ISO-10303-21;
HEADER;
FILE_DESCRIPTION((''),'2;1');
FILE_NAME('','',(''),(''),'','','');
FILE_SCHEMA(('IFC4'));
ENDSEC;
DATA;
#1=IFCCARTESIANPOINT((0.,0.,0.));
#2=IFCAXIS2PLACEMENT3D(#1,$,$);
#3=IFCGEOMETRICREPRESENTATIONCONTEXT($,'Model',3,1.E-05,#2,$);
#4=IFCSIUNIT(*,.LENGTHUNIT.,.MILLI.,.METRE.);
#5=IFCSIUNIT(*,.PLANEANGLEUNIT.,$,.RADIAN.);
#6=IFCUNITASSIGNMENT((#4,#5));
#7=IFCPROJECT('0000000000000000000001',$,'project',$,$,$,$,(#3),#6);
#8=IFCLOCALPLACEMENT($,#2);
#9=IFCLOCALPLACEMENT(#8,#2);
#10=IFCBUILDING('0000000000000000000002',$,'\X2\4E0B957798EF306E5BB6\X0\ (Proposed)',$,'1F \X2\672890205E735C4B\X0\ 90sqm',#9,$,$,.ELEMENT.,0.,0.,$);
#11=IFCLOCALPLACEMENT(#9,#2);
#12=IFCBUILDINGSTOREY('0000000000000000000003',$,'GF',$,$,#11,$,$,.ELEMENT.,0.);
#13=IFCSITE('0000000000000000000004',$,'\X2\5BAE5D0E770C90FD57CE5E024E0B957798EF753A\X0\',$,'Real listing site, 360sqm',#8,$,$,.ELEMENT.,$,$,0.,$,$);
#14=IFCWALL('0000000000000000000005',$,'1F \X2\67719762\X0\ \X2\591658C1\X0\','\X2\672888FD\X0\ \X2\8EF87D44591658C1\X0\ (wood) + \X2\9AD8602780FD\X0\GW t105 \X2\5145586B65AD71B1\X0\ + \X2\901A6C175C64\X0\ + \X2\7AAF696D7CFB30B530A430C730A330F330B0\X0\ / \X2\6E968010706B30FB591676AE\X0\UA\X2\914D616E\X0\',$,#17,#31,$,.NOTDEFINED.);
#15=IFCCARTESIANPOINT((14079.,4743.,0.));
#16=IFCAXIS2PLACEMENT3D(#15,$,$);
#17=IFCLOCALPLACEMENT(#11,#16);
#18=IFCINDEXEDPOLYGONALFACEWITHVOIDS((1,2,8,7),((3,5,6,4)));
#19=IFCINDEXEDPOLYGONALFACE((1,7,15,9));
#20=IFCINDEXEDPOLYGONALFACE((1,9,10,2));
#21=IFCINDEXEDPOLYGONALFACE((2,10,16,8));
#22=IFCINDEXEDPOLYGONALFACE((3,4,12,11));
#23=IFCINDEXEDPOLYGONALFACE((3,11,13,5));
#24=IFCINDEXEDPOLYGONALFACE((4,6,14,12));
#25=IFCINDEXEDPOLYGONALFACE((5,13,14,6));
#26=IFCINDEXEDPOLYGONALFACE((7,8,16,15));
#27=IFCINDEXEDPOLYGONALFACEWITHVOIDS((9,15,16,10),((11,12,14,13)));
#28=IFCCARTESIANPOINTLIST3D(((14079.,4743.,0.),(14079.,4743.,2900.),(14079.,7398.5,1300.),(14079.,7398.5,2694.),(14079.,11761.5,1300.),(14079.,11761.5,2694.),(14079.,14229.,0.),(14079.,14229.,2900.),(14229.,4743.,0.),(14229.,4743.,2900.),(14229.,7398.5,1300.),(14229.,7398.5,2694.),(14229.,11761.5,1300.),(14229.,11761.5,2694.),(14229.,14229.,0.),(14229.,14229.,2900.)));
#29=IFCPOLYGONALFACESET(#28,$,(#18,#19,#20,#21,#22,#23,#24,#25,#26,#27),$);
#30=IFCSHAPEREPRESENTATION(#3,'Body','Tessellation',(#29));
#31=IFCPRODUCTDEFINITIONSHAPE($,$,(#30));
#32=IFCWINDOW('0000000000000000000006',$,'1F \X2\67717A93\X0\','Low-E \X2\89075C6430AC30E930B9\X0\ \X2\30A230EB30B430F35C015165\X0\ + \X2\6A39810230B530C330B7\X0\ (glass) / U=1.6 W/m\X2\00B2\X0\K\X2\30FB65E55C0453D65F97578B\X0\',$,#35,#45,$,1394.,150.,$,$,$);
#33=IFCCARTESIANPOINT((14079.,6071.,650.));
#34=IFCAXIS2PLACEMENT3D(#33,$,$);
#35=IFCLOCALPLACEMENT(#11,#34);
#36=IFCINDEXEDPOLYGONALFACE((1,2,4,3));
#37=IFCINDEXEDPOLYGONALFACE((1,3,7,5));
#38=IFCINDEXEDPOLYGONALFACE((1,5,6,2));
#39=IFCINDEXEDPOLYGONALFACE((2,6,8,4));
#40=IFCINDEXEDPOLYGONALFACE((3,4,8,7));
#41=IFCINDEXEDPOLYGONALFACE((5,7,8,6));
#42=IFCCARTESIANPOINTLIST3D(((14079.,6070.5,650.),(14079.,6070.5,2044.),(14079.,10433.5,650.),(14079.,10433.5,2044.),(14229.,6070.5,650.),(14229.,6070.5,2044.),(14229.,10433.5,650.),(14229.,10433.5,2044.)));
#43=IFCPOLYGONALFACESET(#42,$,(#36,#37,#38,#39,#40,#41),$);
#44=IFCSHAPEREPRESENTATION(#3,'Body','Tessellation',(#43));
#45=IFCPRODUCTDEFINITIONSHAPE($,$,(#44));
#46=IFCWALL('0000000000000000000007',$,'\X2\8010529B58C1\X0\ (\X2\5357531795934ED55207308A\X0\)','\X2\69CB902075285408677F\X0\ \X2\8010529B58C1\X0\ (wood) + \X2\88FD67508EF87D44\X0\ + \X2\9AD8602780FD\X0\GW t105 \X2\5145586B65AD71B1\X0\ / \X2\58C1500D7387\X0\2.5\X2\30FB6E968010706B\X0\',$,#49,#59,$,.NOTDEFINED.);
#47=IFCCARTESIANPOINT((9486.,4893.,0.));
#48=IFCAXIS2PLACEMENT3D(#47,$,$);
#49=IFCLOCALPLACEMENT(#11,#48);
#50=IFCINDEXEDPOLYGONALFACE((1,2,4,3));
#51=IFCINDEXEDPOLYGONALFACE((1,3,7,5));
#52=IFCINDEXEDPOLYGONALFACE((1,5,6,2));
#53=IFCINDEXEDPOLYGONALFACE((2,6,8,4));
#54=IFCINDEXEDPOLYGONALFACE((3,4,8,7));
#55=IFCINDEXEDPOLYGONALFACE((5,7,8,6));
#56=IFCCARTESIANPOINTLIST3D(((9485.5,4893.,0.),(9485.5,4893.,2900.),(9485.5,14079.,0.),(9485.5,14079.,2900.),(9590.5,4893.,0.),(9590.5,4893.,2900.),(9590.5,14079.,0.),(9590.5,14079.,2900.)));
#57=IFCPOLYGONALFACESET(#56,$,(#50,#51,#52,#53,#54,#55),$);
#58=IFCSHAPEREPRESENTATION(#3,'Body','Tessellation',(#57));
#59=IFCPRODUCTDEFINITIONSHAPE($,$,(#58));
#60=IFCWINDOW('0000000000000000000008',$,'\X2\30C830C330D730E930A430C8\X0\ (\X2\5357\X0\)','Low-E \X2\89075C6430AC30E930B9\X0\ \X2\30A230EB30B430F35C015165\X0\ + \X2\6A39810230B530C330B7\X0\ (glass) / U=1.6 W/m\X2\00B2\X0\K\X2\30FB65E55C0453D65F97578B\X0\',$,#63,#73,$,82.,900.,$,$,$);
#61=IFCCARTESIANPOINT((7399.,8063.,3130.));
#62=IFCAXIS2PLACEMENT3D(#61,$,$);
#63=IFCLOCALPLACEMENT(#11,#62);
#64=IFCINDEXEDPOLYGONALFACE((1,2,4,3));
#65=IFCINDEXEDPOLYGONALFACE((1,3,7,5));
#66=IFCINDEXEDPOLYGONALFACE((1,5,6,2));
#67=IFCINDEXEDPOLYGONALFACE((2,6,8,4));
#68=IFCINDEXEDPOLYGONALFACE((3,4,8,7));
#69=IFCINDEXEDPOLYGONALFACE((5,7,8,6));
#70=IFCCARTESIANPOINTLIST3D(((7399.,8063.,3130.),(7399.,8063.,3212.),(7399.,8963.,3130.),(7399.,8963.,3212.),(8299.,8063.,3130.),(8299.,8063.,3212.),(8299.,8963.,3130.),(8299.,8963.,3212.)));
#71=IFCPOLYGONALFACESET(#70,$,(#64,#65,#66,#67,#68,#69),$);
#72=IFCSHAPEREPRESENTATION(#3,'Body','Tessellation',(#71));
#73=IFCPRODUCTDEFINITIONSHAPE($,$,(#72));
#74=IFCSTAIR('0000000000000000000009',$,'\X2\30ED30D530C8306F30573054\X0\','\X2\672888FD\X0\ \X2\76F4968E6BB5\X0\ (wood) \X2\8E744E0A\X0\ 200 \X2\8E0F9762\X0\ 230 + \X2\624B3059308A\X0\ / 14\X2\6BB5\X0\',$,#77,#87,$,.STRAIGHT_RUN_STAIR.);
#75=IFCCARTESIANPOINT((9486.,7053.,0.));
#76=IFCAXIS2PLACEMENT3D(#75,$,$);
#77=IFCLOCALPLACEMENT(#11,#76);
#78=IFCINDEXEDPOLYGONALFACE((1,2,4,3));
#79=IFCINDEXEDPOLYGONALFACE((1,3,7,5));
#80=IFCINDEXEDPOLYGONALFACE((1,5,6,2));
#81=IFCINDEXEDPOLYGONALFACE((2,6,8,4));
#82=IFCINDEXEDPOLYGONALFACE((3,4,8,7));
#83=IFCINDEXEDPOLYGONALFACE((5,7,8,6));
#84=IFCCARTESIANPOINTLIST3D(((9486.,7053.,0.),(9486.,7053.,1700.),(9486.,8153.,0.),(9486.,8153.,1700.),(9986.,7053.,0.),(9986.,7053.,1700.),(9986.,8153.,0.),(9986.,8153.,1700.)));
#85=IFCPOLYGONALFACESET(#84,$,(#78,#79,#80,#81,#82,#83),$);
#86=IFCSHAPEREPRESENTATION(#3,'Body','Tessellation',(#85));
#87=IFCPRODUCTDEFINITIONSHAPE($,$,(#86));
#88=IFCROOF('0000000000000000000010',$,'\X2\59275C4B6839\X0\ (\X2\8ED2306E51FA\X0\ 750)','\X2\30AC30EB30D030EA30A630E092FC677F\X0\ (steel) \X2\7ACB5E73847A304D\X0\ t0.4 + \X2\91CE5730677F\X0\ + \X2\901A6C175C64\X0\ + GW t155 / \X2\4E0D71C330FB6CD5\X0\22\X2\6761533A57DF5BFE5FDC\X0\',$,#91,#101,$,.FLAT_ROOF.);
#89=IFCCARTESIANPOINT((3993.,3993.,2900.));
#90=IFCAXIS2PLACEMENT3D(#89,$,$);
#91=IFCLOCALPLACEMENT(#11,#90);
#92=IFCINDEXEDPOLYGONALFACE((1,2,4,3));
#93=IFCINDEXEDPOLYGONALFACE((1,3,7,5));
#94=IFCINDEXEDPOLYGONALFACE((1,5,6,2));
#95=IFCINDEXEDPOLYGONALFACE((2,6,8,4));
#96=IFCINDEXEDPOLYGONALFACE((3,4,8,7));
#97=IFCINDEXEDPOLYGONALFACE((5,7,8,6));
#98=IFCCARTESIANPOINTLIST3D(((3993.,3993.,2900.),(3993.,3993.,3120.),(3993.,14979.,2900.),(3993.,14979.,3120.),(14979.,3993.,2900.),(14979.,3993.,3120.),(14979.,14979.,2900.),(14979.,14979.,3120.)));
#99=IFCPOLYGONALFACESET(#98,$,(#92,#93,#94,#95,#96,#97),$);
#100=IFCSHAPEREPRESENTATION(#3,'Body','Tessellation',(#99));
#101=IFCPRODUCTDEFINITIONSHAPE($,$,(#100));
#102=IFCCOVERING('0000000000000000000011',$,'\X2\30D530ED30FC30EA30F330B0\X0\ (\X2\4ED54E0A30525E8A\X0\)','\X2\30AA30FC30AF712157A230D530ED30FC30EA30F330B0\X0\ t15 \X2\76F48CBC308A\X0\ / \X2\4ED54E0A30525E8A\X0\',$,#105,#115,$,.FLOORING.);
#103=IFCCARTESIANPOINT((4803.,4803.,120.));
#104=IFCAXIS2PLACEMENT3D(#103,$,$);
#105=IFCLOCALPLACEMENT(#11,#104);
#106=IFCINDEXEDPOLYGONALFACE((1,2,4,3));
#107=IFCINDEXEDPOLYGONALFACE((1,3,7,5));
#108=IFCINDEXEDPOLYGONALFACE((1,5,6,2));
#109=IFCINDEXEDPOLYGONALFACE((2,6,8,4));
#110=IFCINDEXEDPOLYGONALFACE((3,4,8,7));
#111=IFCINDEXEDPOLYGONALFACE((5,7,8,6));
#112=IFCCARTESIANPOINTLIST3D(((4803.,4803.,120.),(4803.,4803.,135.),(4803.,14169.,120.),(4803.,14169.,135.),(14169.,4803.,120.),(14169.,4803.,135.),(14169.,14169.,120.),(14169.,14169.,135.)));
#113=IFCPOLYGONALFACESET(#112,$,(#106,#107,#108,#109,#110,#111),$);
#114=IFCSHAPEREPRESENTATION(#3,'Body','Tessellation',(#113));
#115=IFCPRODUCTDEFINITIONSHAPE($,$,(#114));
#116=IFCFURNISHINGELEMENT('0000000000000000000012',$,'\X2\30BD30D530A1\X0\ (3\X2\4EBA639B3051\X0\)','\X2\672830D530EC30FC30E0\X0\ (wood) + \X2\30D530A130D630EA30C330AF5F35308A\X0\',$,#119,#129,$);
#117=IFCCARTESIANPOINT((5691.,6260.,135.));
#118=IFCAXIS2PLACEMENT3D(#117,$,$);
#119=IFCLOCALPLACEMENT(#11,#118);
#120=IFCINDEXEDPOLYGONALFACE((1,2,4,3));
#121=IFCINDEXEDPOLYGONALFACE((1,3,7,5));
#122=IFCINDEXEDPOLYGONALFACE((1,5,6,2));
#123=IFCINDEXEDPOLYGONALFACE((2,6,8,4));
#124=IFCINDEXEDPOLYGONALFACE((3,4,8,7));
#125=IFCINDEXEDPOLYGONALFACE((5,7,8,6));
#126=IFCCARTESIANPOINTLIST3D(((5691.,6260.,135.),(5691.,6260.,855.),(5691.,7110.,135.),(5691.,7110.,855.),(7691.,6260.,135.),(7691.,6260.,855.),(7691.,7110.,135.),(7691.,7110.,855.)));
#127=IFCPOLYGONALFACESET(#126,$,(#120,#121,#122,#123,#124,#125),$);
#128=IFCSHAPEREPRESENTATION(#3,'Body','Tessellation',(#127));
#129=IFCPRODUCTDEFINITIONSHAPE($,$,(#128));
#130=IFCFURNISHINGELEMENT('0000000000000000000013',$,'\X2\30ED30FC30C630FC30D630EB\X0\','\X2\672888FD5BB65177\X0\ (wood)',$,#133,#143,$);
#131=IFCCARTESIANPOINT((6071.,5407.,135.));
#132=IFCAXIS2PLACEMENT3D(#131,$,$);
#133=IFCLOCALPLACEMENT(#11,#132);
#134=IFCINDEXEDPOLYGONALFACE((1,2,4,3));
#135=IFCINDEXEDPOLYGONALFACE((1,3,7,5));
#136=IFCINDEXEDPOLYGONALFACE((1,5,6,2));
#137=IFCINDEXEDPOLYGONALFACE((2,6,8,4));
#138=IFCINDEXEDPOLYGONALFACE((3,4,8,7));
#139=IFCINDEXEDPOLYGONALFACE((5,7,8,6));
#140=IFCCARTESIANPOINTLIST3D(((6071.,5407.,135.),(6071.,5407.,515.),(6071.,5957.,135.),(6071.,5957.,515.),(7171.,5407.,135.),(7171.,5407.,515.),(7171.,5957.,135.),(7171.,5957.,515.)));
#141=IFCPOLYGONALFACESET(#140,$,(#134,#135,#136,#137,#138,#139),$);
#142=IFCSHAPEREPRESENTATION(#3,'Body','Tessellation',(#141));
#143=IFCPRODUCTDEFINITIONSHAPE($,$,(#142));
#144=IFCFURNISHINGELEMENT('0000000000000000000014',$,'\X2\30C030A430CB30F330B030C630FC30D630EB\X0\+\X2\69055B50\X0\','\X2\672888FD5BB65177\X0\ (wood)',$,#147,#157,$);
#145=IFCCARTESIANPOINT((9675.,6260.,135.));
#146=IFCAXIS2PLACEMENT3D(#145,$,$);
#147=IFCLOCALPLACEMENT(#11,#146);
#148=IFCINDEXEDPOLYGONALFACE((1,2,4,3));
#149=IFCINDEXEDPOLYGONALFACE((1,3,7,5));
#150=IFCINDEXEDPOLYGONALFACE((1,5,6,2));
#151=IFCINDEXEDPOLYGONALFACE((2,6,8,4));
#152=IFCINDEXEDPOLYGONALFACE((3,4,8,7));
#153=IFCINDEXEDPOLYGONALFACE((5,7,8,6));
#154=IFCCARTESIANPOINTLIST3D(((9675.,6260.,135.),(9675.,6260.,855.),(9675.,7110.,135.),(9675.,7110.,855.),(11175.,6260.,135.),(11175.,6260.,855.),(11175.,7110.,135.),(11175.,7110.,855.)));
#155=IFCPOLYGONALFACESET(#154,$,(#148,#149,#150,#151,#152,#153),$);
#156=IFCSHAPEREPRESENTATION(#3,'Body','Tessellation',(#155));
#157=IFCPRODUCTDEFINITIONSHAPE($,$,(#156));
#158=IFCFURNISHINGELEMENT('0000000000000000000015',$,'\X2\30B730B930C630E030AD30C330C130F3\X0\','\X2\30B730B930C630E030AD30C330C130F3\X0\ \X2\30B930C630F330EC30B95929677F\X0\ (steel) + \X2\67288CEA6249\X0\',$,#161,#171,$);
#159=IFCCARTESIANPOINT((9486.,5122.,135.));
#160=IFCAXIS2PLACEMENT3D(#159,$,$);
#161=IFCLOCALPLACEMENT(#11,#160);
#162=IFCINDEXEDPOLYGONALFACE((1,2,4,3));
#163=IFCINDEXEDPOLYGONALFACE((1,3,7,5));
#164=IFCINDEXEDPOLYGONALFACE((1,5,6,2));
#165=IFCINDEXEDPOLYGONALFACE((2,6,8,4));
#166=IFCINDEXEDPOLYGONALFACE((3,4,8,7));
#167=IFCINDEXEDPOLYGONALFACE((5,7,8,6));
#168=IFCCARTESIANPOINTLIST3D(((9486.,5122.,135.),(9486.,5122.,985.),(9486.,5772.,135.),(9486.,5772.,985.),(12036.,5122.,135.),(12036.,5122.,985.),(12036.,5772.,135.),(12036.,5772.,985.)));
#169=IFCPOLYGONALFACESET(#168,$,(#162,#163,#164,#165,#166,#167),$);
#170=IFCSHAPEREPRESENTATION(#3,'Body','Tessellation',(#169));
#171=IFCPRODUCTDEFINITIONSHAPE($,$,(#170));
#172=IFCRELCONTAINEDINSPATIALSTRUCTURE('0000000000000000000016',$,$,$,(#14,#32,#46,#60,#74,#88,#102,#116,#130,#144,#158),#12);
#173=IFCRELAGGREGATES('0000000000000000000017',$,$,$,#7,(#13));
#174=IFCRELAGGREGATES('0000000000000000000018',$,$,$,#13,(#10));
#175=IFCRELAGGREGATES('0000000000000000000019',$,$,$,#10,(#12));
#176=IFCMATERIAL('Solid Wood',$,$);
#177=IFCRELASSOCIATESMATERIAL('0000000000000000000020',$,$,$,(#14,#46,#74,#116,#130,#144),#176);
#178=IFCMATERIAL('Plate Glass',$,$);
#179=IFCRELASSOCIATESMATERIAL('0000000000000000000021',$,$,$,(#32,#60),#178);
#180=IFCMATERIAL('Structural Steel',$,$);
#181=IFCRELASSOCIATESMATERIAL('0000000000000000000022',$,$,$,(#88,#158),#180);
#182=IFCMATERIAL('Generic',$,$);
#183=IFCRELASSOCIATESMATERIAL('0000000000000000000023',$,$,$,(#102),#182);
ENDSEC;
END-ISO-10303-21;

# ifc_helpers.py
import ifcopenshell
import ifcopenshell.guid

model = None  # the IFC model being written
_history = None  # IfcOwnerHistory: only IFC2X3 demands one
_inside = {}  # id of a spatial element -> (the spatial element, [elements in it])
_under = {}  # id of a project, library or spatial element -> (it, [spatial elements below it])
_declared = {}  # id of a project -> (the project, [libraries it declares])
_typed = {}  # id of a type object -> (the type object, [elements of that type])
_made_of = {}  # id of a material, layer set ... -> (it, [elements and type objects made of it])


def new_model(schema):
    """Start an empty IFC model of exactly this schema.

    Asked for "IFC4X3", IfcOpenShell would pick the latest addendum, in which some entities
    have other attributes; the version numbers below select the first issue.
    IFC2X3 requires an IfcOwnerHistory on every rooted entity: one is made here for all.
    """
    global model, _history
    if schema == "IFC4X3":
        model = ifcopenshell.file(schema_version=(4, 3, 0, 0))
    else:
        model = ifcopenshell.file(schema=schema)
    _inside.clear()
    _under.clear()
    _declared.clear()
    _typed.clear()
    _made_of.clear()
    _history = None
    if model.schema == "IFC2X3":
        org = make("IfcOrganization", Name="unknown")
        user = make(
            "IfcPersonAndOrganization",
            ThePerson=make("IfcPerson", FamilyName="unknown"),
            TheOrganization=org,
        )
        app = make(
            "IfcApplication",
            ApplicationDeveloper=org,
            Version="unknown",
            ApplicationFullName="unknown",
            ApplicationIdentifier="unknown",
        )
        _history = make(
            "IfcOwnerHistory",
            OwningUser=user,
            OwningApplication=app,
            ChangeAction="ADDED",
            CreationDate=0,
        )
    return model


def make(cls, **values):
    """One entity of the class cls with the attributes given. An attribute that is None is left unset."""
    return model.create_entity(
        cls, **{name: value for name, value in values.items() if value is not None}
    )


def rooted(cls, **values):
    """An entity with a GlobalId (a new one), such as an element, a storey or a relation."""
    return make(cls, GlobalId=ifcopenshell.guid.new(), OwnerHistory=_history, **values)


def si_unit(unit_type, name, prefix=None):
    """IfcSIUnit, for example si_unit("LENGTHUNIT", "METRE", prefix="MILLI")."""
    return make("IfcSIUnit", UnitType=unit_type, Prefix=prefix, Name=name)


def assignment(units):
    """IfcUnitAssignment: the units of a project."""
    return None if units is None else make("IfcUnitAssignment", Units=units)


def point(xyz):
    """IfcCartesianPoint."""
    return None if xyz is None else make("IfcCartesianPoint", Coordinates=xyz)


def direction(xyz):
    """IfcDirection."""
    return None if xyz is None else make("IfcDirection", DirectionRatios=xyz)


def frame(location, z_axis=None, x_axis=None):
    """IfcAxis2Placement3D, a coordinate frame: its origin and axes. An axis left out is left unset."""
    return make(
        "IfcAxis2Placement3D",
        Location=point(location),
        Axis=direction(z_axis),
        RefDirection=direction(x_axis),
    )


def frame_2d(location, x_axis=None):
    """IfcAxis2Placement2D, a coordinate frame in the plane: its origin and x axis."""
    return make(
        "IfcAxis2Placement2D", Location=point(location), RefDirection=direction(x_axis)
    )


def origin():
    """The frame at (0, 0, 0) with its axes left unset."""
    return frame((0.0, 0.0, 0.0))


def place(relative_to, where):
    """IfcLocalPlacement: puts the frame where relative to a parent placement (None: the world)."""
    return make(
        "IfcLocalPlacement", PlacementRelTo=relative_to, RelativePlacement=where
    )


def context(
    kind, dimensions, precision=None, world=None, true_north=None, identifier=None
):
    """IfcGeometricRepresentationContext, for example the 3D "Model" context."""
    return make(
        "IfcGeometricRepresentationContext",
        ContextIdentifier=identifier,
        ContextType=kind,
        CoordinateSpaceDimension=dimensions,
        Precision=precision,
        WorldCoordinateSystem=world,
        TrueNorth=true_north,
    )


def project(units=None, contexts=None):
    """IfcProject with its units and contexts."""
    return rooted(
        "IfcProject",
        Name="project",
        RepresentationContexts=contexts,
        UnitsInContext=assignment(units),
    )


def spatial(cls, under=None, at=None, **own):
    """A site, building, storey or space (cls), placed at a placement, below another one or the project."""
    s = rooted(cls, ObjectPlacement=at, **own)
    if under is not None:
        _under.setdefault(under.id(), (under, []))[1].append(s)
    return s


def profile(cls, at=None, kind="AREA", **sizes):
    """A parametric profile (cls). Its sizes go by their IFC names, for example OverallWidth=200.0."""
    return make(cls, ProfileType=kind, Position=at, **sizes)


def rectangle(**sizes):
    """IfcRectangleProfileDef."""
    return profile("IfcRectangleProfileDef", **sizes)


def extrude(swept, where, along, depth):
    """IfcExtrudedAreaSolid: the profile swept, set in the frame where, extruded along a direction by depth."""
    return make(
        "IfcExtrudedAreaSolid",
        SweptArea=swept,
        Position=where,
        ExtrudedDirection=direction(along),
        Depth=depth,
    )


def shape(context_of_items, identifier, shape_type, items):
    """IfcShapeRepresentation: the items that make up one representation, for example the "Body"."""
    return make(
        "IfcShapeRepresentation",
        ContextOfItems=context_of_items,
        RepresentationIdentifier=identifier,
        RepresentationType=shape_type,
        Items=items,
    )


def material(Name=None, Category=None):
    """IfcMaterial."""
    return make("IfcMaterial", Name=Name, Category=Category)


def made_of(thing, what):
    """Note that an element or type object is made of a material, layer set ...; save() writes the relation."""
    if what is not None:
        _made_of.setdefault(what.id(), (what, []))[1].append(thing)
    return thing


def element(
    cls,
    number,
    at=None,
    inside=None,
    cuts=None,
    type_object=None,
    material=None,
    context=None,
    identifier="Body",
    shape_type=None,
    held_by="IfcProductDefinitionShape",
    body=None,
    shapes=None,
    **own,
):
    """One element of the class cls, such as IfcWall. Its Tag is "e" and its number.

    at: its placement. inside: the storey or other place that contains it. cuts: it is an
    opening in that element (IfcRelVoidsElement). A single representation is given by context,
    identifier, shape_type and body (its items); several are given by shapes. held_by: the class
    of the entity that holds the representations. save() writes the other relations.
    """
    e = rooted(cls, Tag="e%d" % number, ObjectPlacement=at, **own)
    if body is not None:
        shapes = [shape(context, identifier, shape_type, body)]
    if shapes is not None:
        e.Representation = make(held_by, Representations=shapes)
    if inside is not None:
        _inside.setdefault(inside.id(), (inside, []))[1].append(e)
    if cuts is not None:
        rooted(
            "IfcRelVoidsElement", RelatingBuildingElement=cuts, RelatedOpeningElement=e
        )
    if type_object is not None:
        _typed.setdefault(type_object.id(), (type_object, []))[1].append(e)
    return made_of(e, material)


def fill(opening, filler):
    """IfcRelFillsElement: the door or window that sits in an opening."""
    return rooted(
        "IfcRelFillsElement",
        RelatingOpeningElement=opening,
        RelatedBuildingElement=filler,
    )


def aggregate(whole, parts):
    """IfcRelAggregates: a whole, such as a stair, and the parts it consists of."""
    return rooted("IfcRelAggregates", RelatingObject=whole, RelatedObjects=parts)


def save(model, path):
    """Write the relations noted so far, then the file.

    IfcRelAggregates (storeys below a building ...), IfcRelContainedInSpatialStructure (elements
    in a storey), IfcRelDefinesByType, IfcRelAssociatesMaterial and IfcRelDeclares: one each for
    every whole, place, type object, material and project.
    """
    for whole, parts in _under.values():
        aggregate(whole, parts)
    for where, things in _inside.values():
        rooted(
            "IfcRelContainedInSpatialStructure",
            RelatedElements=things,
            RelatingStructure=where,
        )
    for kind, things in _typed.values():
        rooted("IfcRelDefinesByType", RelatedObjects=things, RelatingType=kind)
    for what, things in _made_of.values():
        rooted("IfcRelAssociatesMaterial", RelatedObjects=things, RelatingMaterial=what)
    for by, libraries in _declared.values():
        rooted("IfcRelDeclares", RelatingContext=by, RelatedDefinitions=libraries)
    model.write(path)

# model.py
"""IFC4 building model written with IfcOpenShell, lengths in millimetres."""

from ifc_helpers import new_model, si_unit, frame, frame_2d, origin, place, context, project, spatial, rectangle, extrude, material, element, fill, save


model = new_model("IFC4")

# Units and contexts
model_context = context("Model", 3, precision=1e-05, world=origin())
ifc_project = project(units=[si_unit("LENGTHUNIT", "METRE", prefix="MILLI"), si_unit("PLANEANGLEUNIT", "RADIAN")], contexts=[model_context])

# Site, building, storey
site_placement = place(None, origin())
site = spatial("IfcSite", under=ifc_project, at=site_placement, Name="宮崎県都城市下長飯町", ObjectType="Real listing site, 360sqm", CompositionType="ELEMENT", RefElevation=0.0)
building_placement = place(site_placement, origin())
building = spatial("IfcBuilding", under=site, at=building_placement, Name="下長飯の家 (Proposed)", ObjectType="1F 木造平屋 90sqm", CompositionType="ELEMENT", ElevationOfRefHeight=0.0, ElevationOfTerrain=0.0)
storey_placement = place(building_placement, origin())
storey = spatial("IfcBuildingStorey", under=building, at=storey_placement, Name="GF", CompositionType="ELEMENT", Elevation=0.0)

# Shared definitions
ifc_material_1 = material(Name="Solid Wood")

# Shared definitions
ifc_material_2 = material(Name="Plate Glass")

# Wall, opening, window
wall_1_placement = place(storey_placement, frame((14079.0, 4743.0, 0.0)))
wall_1 = element("IfcWall", 1, at=wall_1_placement, inside=storey, material=ifc_material_1, Name="1F 東面 外壁", Description="木製 軸組外壁 (wood) + 高性能GW t105 充填断熱 + 通気層 + 窯業系サイディング / 準耐火・外皮UA配慮", PredefinedType="NOTDEFINED", context=model_context, shape_type="SweptSolid", body=[
    extrude(rectangle(XDim=150.0, YDim=9486.0, at=frame_2d((75.0, 4743.0))), frame((14079.0, 4743.0, 0.0)), (0.0, 0.0, 1.0), 2900.0),
])
opening_1_placement = place(storey_placement, frame((14079.0, 6071.0, 650.0)))
opening_1 = element("IfcOpeningElement", 2, at=opening_1_placement, cuts=wall_1, PredefinedType="NOTDEFINED", context=model_context, shape_type="SweptSolid", body=[
    extrude(rectangle(XDim=150.0, YDim=4363.0, at=frame_2d((75.0, 2181.0))), frame((14079.0, 6071.0, 650.0)), (0.0, 0.0, 1.0), 1394.0),
])
window_1_placement = place(storey_placement, frame((14079.0, 6071.0, 650.0)))
window_1 = element("IfcWindow", 3, at=window_1_placement, inside=storey, material=ifc_material_2, Name="1F 東窓", Description="Low-E 複層ガラス アルゴン封入 + 樹脂サッシ (glass) / U=1.6 W/m²K・日射取得型", OverallHeight=1394.0, OverallWidth=150.0, context=model_context, shape_type="SweptSolid", body=[
    extrude(rectangle(XDim=150.0, YDim=4363.0, at=frame_2d((75.0, 2181.0))), frame((14079.0, 6071.0, 650.0)), (0.0, 0.0, 1.0), 1394.0),
])
fill(opening_1, window_1)

# Wall
wall_2_placement = place(storey_placement, frame((9486.0, 4893.0, 0.0)))
element("IfcWall", 4, at=wall_2_placement, inside=storey, material=ifc_material_1, Name="耐力壁 (南北間仕切り)", Description="構造用合板 耐力壁 (wood) + 製材軸組 + 高性能GW t105 充填断熱 / 壁倍率2.5・準耐火", PredefinedType="NOTDEFINED", context=model_context, shape_type="SweptSolid", body=[
    extrude(rectangle(XDim=105.0, YDim=9186.0, at=frame_2d((52.0, 4593.0))), frame((9486.0, 4893.0, 0.0)), (0.0, 0.0, 1.0), 2900.0),
])

# Window
window_2_placement = place(storey_placement, frame((7399.0, 8063.0, 3130.0)))
element("IfcWindow", 5, at=window_2_placement, inside=storey, material=ifc_material_2, Name="トップライト (南)", Description="Low-E 複層ガラス アルゴン封入 + 樹脂サッシ (glass) / U=1.6 W/m²K・日射取得型", OverallHeight=82.0, OverallWidth=900.0, context=model_context, shape_type="SweptSolid", body=[
    extrude(rectangle(XDim=900.0, YDim=900.0, at=frame_2d((450.0, 450.0))), frame((7399.0, 8063.0, 3130.0)), (0.0, 0.0, 1.0), 82.0),
])

# Stair
stair_placement = place(storey_placement, frame((9486.0, 7053.0, 0.0)))
element("IfcStair", 6, at=stair_placement, inside=storey, material=ifc_material_1, Name="ロフトはしご", Description="木製 直階段 (wood) 蹴上 200 踏面 230 + 手すり / 14段", PredefinedType="STRAIGHT_RUN_STAIR", context=model_context, shape_type="SweptSolid", body=[
    extrude(rectangle(XDim=500.0, YDim=1100.0, at=frame_2d((250.0, 550.0))), frame((9486.0, 7053.0, 0.0)), (0.0, 0.0, 1.0), 1700.0),
])

# Roof
ifc_material_3 = material(Name="Structural Steel")
roof_placement = place(storey_placement, frame((3993.0, 3993.0, 2900.0)))
element("IfcRoof", 7, at=roof_placement, inside=storey, material=ifc_material_3, Name="大屋根 (軒の出 750)", Description="ガルバリウム鋼板 (steel) 立平葺き t0.4 + 野地板 + 通気層 + GW t155 / 不燃・法22条区域対応", PredefinedType="FLAT_ROOF", context=model_context, shape_type="SweptSolid", body=[
    extrude(rectangle(XDim=10986.0, YDim=10986.0, at=frame_2d((5493.0, 5493.0))), frame((3993.0, 3993.0, 2900.0)), (0.0, 0.0, 1.0), 220.0),
])

# Covering
ifc_material_4 = material(Name="Generic")
covering_placement = place(storey_placement, frame((4803.0, 4803.0, 120.0)))
element("IfcCovering", 8, at=covering_placement, inside=storey, material=ifc_material_4, Name="フローリング (仕上げ床)", Description="オーク無垢フローリング t15 直貼り / 仕上げ床", PredefinedType="FLOORING", context=model_context, shape_type="SweptSolid", body=[
    extrude(rectangle(XDim=9366.0, YDim=9366.0, at=frame_2d((4683.0, 4683.0))), frame((4803.0, 4803.0, 120.0)), (0.0, 0.0, 1.0), 15.0),
])

# Furnishing elements
furnishing_1_placement = place(storey_placement, frame((5691.0, 6260.0, 135.0)))
element("IfcFurnishingElement", 9, at=furnishing_1_placement, inside=storey, material=ifc_material_1, Name="ソファ (3人掛け)", Description="木フレーム (wood) + ファブリック張り", context=model_context, shape_type="SweptSolid", body=[
    extrude(rectangle(XDim=2000.0, YDim=850.0, at=frame_2d((1000.0, 425.0))), frame((5691.0, 6260.0, 135.0)), (0.0, 0.0, 1.0), 720.0),
])
furnishing_2_placement = place(storey_placement, frame((6071.0, 5407.0, 135.0)))
element("IfcFurnishingElement", 10, at=furnishing_2_placement, inside=storey, material=ifc_material_1, Name="ローテーブル", Description="木製家具 (wood)", context=model_context, shape_type="SweptSolid", body=[
    extrude(rectangle(XDim=1100.0, YDim=550.0, at=frame_2d((550.0, 275.0))), frame((6071.0, 5407.0, 135.0)), (0.0, 0.0, 1.0), 380.0),
])
furnishing_3_placement = place(storey_placement, frame((9675.0, 6260.0, 135.0)))
element("IfcFurnishingElement", 11, at=furnishing_3_placement, inside=storey, material=ifc_material_1, Name="ダイニングテーブル+椅子", Description="木製家具 (wood)", context=model_context, shape_type="SweptSolid", body=[
    extrude(rectangle(XDim=1500.0, YDim=850.0, at=frame_2d((750.0, 425.0))), frame((9675.0, 6260.0, 135.0)), (0.0, 0.0, 1.0), 720.0),
])
furnishing_4_placement = place(storey_placement, frame((9486.0, 5122.0, 135.0)))
element("IfcFurnishingElement", 12, at=furnishing_4_placement, inside=storey, material=ifc_material_3, Name="システムキッチン", Description="システムキッチン ステンレス天板 (steel) + 木質扉", context=model_context, shape_type="SweptSolid", body=[
    extrude(rectangle(XDim=2550.0, YDim=650.0, at=frame_2d((1275.0, 325.0))), frame((9486.0, 5122.0, 135.0)), (0.0, 0.0, 1.0), 850.0),
])

save(model, "model.ifc")
